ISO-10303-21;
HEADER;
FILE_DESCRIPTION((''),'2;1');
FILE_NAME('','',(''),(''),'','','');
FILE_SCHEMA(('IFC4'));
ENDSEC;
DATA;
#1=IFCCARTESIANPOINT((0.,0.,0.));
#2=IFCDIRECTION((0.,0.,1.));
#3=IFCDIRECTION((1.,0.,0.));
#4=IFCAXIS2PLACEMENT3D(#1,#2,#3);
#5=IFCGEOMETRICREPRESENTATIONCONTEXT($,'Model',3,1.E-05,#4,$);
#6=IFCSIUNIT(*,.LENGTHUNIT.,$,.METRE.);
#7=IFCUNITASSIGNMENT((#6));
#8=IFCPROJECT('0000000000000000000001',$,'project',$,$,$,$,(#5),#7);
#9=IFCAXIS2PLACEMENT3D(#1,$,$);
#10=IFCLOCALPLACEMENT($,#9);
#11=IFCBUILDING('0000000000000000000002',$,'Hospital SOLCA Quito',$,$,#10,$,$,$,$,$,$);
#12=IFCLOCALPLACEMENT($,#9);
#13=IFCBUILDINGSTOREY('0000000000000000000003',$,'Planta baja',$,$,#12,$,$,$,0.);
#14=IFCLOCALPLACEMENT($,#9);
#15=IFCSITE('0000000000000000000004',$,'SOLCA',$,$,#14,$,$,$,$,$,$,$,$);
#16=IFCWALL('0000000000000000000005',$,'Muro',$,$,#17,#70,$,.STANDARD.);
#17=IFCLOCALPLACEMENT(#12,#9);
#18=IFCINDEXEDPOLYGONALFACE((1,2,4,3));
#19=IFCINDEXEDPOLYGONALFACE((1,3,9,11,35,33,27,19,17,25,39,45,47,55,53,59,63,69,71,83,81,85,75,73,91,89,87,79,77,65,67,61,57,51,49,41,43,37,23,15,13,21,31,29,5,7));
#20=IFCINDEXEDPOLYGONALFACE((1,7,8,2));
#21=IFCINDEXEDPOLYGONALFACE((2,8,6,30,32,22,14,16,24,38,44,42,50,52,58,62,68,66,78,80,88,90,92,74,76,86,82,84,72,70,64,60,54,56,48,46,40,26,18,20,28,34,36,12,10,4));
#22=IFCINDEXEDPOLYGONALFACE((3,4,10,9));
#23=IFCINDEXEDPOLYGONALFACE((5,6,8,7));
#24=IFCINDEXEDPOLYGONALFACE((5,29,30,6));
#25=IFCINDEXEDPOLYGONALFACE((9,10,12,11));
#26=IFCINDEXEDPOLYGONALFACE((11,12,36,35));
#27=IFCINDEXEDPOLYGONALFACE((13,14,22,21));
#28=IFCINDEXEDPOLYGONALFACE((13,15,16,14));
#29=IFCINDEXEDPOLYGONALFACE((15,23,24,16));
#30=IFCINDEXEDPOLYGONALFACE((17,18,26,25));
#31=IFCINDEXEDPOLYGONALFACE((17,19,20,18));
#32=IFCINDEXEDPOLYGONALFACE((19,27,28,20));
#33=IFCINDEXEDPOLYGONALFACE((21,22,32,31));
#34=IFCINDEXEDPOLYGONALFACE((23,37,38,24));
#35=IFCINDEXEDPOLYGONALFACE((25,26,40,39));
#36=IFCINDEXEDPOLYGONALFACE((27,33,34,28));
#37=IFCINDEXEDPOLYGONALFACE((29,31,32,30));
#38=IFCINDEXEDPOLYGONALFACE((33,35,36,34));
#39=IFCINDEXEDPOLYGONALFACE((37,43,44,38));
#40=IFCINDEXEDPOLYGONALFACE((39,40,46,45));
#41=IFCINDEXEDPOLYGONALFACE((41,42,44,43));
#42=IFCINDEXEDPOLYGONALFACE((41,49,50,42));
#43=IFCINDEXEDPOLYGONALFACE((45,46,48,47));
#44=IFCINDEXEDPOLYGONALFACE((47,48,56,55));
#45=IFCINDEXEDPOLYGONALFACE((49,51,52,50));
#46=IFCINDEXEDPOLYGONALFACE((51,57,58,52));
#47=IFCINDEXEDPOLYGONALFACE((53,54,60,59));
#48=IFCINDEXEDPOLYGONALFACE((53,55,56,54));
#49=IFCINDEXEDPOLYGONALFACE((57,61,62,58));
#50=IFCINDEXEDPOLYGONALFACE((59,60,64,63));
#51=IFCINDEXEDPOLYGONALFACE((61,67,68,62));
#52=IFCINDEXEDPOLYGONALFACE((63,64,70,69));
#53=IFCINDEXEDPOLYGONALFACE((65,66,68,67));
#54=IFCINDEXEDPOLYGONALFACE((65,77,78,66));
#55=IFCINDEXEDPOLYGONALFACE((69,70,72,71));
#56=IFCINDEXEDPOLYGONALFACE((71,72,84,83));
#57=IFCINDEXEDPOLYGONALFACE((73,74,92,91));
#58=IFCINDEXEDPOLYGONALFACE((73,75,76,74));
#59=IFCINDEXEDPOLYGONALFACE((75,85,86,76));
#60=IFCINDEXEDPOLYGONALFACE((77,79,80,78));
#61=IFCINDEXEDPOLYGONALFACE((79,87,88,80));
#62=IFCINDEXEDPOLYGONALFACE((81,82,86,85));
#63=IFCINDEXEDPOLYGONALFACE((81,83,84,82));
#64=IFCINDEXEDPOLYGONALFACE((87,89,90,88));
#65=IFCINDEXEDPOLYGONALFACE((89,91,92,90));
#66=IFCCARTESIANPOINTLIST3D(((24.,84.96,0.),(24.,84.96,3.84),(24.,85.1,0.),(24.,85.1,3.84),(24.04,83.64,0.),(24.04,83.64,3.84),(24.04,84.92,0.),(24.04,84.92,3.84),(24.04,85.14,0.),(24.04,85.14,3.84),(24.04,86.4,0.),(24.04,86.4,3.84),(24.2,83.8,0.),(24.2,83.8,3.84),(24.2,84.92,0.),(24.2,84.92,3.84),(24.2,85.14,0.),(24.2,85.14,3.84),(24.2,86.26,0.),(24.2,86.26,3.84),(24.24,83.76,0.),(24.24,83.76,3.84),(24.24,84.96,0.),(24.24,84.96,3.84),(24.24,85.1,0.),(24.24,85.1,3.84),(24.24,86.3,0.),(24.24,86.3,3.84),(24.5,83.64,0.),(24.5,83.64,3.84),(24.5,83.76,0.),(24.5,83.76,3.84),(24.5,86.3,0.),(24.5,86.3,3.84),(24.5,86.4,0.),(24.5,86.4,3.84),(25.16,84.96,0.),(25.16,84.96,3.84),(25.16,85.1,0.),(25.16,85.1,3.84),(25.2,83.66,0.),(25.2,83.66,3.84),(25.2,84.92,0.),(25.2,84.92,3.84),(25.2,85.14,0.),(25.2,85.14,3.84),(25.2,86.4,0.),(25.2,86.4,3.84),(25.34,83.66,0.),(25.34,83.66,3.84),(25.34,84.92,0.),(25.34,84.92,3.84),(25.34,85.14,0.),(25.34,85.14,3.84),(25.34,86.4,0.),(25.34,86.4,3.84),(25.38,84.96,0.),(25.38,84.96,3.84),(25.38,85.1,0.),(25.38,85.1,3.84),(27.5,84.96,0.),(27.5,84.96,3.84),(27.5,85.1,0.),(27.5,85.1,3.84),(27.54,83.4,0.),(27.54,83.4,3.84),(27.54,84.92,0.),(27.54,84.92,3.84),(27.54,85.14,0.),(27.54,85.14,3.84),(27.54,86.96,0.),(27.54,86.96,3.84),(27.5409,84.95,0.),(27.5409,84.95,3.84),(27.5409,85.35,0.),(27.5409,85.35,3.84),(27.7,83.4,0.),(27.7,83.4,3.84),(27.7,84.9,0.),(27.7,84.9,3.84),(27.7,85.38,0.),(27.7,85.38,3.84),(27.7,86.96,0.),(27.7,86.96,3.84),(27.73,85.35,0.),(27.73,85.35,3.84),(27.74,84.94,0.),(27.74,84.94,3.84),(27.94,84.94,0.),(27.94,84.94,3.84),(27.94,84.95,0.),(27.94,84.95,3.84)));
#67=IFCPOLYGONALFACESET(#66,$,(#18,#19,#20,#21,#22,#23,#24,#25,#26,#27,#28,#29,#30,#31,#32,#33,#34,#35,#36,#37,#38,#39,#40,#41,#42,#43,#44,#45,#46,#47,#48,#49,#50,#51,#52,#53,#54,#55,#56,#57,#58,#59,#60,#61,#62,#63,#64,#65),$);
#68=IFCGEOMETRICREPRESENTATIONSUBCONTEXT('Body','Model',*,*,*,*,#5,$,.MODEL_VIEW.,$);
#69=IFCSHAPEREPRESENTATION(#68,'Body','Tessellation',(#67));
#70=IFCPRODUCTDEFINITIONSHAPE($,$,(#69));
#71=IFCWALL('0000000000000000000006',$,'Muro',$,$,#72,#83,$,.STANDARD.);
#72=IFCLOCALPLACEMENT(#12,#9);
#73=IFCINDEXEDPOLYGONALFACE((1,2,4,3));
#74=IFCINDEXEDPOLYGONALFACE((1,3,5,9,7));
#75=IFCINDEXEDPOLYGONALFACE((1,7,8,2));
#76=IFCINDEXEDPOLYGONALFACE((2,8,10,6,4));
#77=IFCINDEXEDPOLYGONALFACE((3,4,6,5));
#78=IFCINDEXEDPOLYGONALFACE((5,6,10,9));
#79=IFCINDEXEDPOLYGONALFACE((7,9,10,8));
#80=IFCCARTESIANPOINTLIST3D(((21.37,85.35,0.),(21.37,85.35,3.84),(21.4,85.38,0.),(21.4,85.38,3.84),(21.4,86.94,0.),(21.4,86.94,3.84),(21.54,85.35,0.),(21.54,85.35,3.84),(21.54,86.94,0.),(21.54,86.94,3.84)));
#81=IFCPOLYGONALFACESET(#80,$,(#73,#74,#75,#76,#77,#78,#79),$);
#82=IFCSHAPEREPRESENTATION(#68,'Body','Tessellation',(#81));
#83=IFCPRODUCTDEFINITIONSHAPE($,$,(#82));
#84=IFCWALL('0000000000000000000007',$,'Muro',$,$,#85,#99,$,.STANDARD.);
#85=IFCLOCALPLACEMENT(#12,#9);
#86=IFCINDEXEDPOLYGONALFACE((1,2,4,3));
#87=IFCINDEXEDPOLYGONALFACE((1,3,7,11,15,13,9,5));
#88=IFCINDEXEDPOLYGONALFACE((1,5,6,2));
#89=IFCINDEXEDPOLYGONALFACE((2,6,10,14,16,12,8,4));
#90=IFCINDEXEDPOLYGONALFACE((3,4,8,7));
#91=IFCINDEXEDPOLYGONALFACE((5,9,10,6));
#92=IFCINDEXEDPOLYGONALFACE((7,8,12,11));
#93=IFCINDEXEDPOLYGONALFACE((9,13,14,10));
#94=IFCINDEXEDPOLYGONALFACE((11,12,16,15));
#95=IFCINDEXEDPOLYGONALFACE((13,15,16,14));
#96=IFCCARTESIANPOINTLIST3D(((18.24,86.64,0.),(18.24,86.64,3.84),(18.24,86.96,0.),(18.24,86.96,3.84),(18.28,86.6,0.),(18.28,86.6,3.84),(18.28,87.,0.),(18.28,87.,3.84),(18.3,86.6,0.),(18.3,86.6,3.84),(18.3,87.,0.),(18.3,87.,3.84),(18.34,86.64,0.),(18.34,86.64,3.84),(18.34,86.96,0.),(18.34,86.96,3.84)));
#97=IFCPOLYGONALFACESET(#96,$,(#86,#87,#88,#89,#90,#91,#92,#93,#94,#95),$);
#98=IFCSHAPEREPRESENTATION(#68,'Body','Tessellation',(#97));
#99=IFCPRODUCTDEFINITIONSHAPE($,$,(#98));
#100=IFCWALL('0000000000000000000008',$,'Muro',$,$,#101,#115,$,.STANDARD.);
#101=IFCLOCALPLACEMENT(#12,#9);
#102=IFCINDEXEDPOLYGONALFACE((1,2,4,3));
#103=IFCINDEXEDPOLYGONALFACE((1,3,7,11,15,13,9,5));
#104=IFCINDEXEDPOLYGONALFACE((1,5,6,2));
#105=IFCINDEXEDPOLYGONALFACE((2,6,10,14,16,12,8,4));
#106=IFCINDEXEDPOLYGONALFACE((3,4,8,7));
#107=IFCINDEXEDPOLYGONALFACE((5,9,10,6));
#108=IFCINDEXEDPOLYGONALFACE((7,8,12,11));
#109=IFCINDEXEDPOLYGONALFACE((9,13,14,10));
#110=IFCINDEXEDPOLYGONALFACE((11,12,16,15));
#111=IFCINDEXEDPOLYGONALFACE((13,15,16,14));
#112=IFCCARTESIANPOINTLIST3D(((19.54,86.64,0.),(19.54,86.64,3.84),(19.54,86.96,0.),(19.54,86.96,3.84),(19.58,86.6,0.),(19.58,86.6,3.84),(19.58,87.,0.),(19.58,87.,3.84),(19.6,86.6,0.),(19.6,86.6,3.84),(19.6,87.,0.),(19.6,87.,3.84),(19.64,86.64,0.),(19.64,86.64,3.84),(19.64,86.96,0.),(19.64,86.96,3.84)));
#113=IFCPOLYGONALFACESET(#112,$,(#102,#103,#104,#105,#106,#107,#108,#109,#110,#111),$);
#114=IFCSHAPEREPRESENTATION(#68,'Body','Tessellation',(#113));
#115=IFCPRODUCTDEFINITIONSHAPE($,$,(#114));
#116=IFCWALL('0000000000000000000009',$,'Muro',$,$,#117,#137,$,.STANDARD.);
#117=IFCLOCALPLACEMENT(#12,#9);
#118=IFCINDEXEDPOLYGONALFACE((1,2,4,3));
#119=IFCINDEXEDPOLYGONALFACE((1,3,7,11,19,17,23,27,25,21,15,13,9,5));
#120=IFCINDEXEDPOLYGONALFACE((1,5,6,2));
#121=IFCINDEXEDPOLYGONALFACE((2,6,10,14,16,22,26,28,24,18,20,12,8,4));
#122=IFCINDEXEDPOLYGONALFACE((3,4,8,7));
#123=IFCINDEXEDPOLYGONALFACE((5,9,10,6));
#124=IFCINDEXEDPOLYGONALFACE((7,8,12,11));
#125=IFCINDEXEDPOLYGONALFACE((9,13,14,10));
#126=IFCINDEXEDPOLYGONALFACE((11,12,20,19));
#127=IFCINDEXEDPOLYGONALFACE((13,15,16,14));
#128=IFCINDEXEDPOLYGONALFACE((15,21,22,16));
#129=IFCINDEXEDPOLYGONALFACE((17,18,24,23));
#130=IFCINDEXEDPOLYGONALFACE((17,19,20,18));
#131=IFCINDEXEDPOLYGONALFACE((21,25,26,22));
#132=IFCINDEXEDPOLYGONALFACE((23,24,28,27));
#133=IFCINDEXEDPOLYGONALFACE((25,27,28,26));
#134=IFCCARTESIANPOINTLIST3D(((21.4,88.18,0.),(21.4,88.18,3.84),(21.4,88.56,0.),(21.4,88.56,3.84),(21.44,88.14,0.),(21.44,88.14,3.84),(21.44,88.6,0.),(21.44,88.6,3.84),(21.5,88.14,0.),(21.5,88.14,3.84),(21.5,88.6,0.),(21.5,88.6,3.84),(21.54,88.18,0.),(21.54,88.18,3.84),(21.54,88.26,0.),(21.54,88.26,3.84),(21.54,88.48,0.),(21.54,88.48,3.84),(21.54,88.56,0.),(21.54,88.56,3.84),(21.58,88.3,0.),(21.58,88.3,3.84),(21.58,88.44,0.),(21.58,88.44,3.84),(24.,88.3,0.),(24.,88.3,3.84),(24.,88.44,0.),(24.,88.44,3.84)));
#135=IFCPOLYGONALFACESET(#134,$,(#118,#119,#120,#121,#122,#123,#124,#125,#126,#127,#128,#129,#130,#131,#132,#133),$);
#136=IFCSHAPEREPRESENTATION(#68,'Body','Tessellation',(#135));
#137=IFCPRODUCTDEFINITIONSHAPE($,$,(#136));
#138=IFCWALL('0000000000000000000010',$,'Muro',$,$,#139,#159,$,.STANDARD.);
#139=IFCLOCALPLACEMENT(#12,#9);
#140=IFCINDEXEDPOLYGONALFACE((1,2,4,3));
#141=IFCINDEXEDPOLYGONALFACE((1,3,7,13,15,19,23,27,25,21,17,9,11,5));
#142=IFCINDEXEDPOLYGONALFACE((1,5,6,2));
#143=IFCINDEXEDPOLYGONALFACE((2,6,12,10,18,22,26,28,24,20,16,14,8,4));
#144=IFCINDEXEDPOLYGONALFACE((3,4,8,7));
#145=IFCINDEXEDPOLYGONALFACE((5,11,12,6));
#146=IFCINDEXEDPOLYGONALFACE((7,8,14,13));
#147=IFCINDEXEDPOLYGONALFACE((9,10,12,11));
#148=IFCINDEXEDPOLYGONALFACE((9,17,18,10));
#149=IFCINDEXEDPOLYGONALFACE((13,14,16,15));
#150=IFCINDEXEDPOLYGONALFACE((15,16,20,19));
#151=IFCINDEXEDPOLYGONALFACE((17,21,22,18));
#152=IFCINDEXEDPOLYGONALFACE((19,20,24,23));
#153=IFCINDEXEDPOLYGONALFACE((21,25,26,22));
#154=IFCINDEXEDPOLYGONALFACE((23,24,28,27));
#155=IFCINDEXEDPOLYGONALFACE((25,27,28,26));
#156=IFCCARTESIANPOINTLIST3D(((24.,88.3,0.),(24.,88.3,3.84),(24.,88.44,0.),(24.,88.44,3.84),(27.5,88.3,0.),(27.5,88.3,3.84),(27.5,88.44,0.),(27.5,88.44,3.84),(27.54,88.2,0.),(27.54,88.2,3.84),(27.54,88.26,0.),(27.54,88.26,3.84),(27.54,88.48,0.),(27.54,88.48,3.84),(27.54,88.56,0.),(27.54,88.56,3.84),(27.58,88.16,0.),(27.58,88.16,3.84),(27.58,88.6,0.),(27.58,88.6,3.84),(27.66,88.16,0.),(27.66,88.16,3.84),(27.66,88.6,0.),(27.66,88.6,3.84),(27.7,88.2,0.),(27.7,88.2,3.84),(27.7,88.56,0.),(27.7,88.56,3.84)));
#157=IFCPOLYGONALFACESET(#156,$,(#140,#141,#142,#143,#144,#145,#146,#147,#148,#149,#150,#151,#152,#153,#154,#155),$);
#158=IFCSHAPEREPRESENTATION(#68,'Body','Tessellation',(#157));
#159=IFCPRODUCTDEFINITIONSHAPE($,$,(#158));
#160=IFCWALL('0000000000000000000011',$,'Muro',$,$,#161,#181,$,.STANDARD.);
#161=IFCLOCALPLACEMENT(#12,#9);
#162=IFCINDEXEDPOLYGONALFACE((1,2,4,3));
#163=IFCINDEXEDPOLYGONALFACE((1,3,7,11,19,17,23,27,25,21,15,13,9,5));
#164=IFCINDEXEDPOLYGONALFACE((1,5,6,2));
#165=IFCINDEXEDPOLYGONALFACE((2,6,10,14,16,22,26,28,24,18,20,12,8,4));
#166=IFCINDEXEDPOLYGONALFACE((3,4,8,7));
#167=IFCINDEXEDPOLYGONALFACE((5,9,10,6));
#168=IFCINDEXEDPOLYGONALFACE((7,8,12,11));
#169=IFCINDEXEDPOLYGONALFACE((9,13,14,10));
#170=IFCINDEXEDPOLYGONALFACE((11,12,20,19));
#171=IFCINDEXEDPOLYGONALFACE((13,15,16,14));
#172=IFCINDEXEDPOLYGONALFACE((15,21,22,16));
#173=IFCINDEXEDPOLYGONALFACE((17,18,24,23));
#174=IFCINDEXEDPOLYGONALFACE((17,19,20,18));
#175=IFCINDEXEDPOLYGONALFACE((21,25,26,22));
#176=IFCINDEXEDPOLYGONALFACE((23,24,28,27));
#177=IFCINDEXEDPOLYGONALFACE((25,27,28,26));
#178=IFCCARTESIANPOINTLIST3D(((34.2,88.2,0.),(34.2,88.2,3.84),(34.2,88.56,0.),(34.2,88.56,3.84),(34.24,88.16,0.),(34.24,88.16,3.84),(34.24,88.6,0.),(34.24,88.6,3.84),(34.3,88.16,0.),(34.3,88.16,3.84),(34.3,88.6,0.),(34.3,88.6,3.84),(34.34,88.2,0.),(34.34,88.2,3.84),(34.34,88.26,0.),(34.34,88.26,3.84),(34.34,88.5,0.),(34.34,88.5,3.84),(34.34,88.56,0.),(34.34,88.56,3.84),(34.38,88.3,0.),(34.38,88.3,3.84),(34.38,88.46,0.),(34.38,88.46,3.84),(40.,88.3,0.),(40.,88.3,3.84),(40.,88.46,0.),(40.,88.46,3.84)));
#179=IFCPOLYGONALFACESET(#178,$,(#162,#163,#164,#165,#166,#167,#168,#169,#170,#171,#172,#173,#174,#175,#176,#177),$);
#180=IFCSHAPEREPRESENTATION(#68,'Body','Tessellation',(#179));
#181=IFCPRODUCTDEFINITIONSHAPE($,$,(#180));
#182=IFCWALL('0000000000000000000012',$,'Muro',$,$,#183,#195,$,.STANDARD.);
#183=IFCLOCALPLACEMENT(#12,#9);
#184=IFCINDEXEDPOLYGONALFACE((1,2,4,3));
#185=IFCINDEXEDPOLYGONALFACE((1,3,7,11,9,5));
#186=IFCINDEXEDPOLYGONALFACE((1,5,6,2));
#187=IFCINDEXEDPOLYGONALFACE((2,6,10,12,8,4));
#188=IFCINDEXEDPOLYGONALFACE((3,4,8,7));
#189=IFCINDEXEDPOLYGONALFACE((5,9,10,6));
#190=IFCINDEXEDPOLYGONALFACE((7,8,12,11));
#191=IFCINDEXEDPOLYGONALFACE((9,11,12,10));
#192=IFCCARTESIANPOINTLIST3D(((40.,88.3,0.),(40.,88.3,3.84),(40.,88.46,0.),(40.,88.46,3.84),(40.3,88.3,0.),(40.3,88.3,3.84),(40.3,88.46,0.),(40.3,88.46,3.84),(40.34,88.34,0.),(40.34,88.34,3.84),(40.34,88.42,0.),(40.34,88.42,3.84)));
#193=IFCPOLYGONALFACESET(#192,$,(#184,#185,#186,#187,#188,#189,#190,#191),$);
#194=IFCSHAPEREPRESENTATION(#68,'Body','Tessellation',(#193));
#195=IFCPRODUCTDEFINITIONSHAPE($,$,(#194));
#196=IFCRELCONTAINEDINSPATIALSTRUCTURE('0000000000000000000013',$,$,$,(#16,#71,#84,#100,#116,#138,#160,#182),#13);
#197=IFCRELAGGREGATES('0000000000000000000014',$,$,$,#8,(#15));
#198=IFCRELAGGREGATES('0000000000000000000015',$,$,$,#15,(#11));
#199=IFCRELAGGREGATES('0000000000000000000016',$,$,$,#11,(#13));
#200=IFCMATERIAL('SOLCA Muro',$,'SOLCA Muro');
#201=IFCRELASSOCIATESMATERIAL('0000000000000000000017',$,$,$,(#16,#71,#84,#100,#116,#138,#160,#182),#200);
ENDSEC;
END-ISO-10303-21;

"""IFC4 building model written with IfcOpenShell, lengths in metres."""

from ifc_helpers import new_model, si_unit, origin, origin_with_axes, place, context, subcontext, project, spatial, polyline, outline, extrude, material, element, save


model = new_model("IFC4")

# Units and contexts
model_context = context("Model", 3, precision=1e-05, world=origin_with_axes())
body_context = subcontext(model_context, "Body", "Model", "MODEL_VIEW")
ifc_project = project(units=[si_unit("LENGTHUNIT", "METRE")], contexts=[model_context])

# Site, building, storey
site_placement = place(None, origin())
site = spatial("IfcSite", under=ifc_project, at=site_placement, Name="SOLCA")
building_placement = place(None, origin())
building = spatial("IfcBuilding", under=site, at=building_placement, Name="Hospital SOLCA Quito")
storey_placement = place(None, origin())
storey = spatial("IfcBuildingStorey", under=building, at=storey_placement, Name="Planta baja", Elevation=0.0)

# Walls
ifc_material = material(Name="SOLCA Muro", Category="SOLCA Muro")
wall_1_placement = place(storey_placement, origin_with_axes())
element("IfcWall", 1, at=wall_1_placement, inside=storey, material=ifc_material, Name="Muro", PredefinedType="STANDARD", context=body_context, shape_type="SweptSolid", body=[
    extrude(outline(polyline([(24.2, 84.92), (24.2, 83.8), (24.24, 83.76), (24.5, 83.76), (24.5, 83.64), (24.04, 83.64), (24.04, 84.92), (24.0, 84.96), (24.0, 85.1), (24.04, 85.14), (24.04, 86.4), (24.5, 86.4), (24.5, 86.3), (24.24, 86.3), (24.2, 86.26), (24.2, 85.14), (24.24, 85.1), (25.16, 85.1), (25.2, 85.14), (25.2, 86.4), (25.34, 86.4), (25.34, 85.14), (25.38, 85.1), (27.5, 85.1), (27.54, 85.14), (27.54, 86.96), (27.7, 86.96), (27.7, 85.38), (27.73, 85.35), (27.5409, 85.35), (27.5409, 84.95), (27.94, 84.95), (27.94, 84.94), (27.74, 84.94), (27.7, 84.9), (27.7, 83.4), (27.54, 83.4), (27.54, 84.92), (27.5, 84.96), (25.38, 84.96), (25.34, 84.92), (25.34, 83.66), (25.2, 83.66), (25.2, 84.92), (25.16, 84.96), (24.24, 84.96), (24.2, 84.92)])), origin_with_axes(), (0.0, 0.0, 1.0), 3.84),
])
wall_2_placement = place(storey_placement, origin_with_axes())
element("IfcWall", 2, at=wall_2_placement, inside=storey, material=ifc_material, Name="Muro", PredefinedType="STANDARD", context=body_context, shape_type="SweptSolid", body=[
    extrude(outline(polyline([(21.4, 86.94), (21.54, 86.94), (21.54, 85.35), (21.37, 85.35), (21.4, 85.38), (21.4, 86.94)])), origin_with_axes(), (0.0, 0.0, 1.0), 3.84),
])
wall_3_placement = place(storey_placement, origin_with_axes())
element("IfcWall", 3, at=wall_3_placement, inside=storey, material=ifc_material, Name="Muro", PredefinedType="STANDARD", context=body_context, shape_type="SweptSolid", body=[
    extrude(outline(polyline([(18.34, 86.96), (18.34, 86.64), (18.3, 86.6), (18.28, 86.6), (18.24, 86.64), (18.24, 86.96), (18.28, 87.0), (18.3, 87.0), (18.34, 86.96)])), origin_with_axes(), (0.0, 0.0, 1.0), 3.84),
])
wall_4_placement = place(storey_placement, origin_with_axes())
element("IfcWall", 4, at=wall_4_placement, inside=storey, material=ifc_material, Name="Muro", PredefinedType="STANDARD", context=body_context, shape_type="SweptSolid", body=[
    extrude(outline(polyline([(19.64, 86.64), (19.6, 86.6), (19.58, 86.6), (19.54, 86.64), (19.54, 86.96), (19.58, 87.0), (19.6, 87.0), (19.64, 86.96), (19.64, 86.64)])), origin_with_axes(), (0.0, 0.0, 1.0), 3.84),
])
wall_5_placement = place(storey_placement, origin_with_axes())
element("IfcWall", 5, at=wall_5_placement, inside=storey, material=ifc_material, Name="Muro", PredefinedType="STANDARD", context=body_context, shape_type="SweptSolid", body=[
    extrude(outline(polyline([(21.54, 88.18), (21.5, 88.14), (21.44, 88.14), (21.4, 88.18), (21.4, 88.56), (21.44, 88.6), (21.5, 88.6), (21.54, 88.56), (21.54, 88.48), (21.58, 88.44), (24.0, 88.44), (24.0, 88.3), (21.58, 88.3), (21.54, 88.26), (21.54, 88.18)])), origin_with_axes(), (0.0, 0.0, 1.0), 3.84),
])
wall_6_placement = place(storey_placement, origin_with_axes())
element("IfcWall", 6, at=wall_6_placement, inside=storey, material=ifc_material, Name="Muro", PredefinedType="STANDARD", context=body_context, shape_type="SweptSolid", body=[
    extrude(outline(polyline([(27.5, 88.44), (27.54, 88.48), (27.54, 88.56), (27.58, 88.6), (27.66, 88.6), (27.7, 88.56), (27.7, 88.2), (27.66, 88.16), (27.58, 88.16), (27.54, 88.2), (27.54, 88.26), (27.5, 88.3), (24.0, 88.3), (24.0, 88.44), (27.5, 88.44)])), origin_with_axes(), (0.0, 0.0, 1.0), 3.84),
])
wall_7_placement = place(storey_placement, origin_with_axes())
element("IfcWall", 7, at=wall_7_placement, inside=storey, material=ifc_material, Name="Muro", PredefinedType="STANDARD", context=body_context, shape_type="SweptSolid", body=[
    extrude(outline(polyline([(34.34, 88.56), (34.34, 88.5), (34.38, 88.46), (40.0, 88.46), (40.0, 88.3), (34.38, 88.3), (34.34, 88.26), (34.34, 88.2), (34.3, 88.16), (34.24, 88.16), (34.2, 88.2), (34.2, 88.56), (34.24, 88.6), (34.3, 88.6), (34.34, 88.56)])), origin_with_axes(), (0.0, 0.0, 1.0), 3.84),
])
wall_8_placement = place(storey_placement, origin_with_axes())
element("IfcWall", 8, at=wall_8_placement, inside=storey, material=ifc_material, Name="Muro", PredefinedType="STANDARD", context=body_context, shape_type="SweptSolid", body=[
    extrude(outline(polyline([(40.3, 88.46), (40.34, 88.42), (40.34, 88.34), (40.3, 88.3), (40.0, 88.3), (40.0, 88.46), (40.3, 88.46)])), origin_with_axes(), (0.0, 0.0, 1.0), 3.84),
])

save(model, "model.ifc")
